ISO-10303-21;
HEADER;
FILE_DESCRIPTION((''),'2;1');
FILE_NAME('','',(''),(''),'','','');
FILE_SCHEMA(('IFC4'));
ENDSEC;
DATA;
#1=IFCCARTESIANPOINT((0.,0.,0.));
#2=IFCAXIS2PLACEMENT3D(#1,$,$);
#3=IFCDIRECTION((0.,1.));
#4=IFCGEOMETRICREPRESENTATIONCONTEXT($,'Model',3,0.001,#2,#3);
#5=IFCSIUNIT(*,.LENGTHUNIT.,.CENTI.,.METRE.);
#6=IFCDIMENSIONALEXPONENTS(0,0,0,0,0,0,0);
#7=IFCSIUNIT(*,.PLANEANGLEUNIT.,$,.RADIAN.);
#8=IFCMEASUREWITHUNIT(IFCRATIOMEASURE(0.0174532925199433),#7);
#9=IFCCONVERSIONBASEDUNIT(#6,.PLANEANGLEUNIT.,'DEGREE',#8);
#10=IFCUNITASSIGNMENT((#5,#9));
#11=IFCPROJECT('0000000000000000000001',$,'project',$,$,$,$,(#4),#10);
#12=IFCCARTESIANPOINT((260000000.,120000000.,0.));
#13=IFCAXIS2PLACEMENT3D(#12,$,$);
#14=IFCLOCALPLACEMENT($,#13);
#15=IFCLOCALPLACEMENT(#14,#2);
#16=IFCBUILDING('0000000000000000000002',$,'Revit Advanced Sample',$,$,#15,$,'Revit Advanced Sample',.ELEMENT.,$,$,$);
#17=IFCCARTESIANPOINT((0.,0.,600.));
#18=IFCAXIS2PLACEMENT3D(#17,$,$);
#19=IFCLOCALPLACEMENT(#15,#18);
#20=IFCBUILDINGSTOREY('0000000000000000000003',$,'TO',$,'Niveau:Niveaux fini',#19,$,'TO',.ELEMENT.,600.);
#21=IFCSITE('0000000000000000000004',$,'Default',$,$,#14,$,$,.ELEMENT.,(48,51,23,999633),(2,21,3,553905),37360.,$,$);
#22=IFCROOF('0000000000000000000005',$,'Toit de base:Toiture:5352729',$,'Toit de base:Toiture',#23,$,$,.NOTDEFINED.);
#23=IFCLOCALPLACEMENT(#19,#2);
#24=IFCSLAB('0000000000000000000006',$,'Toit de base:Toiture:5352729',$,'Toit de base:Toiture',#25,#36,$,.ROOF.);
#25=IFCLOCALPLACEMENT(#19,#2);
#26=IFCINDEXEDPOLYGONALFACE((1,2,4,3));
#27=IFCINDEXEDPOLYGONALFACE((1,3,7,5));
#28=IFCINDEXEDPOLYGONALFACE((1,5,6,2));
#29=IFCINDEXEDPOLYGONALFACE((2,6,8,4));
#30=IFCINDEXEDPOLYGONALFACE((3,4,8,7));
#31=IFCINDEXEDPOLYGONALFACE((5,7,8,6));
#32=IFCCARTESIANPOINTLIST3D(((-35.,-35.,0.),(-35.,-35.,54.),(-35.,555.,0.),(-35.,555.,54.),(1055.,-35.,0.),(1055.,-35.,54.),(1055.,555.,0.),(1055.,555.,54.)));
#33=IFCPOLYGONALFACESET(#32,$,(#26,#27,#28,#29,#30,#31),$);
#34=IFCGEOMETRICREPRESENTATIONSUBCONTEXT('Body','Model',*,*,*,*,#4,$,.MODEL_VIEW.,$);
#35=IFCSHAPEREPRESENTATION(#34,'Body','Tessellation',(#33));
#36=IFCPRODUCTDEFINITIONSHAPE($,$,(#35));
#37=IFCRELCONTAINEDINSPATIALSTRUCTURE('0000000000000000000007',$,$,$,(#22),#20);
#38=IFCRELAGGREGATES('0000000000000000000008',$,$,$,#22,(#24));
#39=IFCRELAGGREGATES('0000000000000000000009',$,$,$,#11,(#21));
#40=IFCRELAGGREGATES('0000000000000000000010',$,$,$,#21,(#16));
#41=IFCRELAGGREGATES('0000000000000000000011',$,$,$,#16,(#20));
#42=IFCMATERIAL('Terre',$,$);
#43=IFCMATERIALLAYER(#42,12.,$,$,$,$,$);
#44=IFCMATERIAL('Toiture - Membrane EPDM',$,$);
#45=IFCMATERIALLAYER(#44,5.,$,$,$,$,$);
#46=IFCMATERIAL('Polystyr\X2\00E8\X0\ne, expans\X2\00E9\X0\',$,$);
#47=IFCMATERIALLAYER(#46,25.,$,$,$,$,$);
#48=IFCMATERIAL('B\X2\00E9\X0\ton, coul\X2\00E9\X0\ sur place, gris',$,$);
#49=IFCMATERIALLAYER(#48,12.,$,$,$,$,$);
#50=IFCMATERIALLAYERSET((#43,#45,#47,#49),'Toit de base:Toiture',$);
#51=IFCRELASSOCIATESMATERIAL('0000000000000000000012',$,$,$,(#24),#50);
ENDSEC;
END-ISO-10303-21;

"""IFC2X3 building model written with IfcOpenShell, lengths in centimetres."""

from ifc_helpers import new_model, entity, si_unit, converted_unit, direction, frame, frame_2d, origin, place, context, subcontext, project, spatial, rectangle, extrude, material, layer, layer_set, element, aggregate, save


model = new_model("IFC2X3")

# Units and contexts
model_context = context("Model", 3, precision=0.001, world=origin(), true_north=direction((0.0, 1.0)))
body_context = subcontext(model_context, "Body", "Model", "MODEL_VIEW")
ifc_project = project(units=[si_unit("LENGTHUNIT", "METRE", prefix="CENTI"), converted_unit("PLANEANGLEUNIT", "DEGREE", entity("IfcRatioMeasure", 0.0174532925199433), si_unit("PLANEANGLEUNIT", "RADIAN"), dimensions=[0, 0, 0, 0, 0, 0, 0])], contexts=[model_context])

# Site, building, storey
site_placement = place(None, frame((260000000.0, 120000000.0, 0.0)))
site = spatial("IfcSite", under=ifc_project, at=site_placement, Name="Default", CompositionType="ELEMENT", RefLatitude=(48, 51, 23, 999633), RefLongitude=(2, 21, 3, 553905), RefElevation=37360.0)
building_placement = place(site_placement, origin())
building = spatial("IfcBuilding", under=site, at=building_placement, Name="Revit Advanced Sample", LongName="Revit Advanced Sample", CompositionType="ELEMENT")
storey_placement = place(building_placement, frame((0.0, 0.0, 600.0)))
storey = spatial("IfcBuildingStorey", under=building, at=storey_placement, Name="TO", ObjectType="Niveau:Niveaux fini", LongName="TO", CompositionType="ELEMENT", Elevation=600.0)

# Roof, slab
roof_placement = place(storey_placement, frame((-35.0, -35.0, 0.0)))
roof = element("IfcRoof", 1, at=roof_placement, inside=storey, Name="Toit de base:Toiture:5352729", ObjectType="Toit de base:Toiture", ShapeType="NOTDEFINED")
ifc_material_1 = material(Name="Terre")
ifc_layer_1 = layer(ifc_material_1, 12.0)
ifc_material_2 = material(Name="Toiture - Membrane EPDM")
ifc_layer_2 = layer(ifc_material_2, 5.0)
ifc_material_3 = material(Name="Polystyrène, expansé")
ifc_layer_3 = layer(ifc_material_3, 25.0)
ifc_material_4 = material(Name="Béton, coulé sur place, gris")
ifc_layer_4 = layer(ifc_material_4, 12.0)
ifc_layer_set = layer_set([ifc_layer_1, ifc_layer_2, ifc_layer_3, ifc_layer_4], Name="Toit de base:Toiture")
slab_placement = place(roof_placement, origin())
slab = element("IfcSlab", 2, at=slab_placement, material=ifc_layer_set, Name="Toit de base:Toiture:5352729", ObjectType="Toit de base:Toiture", PredefinedType="ROOF", context=body_context, shape_type="SweptSolid", body=[
    extrude(rectangle(XDim=1090.0, YDim=590.0, at=frame_2d((0.0, 0.0), x_axis=(1.0, 0.0))), frame((545.0, 295.0, 0.0)), (0.0, 0.0, 1.0), 54.0),
])
aggregate(roof, [slab])

save(model, "model.ifc")
